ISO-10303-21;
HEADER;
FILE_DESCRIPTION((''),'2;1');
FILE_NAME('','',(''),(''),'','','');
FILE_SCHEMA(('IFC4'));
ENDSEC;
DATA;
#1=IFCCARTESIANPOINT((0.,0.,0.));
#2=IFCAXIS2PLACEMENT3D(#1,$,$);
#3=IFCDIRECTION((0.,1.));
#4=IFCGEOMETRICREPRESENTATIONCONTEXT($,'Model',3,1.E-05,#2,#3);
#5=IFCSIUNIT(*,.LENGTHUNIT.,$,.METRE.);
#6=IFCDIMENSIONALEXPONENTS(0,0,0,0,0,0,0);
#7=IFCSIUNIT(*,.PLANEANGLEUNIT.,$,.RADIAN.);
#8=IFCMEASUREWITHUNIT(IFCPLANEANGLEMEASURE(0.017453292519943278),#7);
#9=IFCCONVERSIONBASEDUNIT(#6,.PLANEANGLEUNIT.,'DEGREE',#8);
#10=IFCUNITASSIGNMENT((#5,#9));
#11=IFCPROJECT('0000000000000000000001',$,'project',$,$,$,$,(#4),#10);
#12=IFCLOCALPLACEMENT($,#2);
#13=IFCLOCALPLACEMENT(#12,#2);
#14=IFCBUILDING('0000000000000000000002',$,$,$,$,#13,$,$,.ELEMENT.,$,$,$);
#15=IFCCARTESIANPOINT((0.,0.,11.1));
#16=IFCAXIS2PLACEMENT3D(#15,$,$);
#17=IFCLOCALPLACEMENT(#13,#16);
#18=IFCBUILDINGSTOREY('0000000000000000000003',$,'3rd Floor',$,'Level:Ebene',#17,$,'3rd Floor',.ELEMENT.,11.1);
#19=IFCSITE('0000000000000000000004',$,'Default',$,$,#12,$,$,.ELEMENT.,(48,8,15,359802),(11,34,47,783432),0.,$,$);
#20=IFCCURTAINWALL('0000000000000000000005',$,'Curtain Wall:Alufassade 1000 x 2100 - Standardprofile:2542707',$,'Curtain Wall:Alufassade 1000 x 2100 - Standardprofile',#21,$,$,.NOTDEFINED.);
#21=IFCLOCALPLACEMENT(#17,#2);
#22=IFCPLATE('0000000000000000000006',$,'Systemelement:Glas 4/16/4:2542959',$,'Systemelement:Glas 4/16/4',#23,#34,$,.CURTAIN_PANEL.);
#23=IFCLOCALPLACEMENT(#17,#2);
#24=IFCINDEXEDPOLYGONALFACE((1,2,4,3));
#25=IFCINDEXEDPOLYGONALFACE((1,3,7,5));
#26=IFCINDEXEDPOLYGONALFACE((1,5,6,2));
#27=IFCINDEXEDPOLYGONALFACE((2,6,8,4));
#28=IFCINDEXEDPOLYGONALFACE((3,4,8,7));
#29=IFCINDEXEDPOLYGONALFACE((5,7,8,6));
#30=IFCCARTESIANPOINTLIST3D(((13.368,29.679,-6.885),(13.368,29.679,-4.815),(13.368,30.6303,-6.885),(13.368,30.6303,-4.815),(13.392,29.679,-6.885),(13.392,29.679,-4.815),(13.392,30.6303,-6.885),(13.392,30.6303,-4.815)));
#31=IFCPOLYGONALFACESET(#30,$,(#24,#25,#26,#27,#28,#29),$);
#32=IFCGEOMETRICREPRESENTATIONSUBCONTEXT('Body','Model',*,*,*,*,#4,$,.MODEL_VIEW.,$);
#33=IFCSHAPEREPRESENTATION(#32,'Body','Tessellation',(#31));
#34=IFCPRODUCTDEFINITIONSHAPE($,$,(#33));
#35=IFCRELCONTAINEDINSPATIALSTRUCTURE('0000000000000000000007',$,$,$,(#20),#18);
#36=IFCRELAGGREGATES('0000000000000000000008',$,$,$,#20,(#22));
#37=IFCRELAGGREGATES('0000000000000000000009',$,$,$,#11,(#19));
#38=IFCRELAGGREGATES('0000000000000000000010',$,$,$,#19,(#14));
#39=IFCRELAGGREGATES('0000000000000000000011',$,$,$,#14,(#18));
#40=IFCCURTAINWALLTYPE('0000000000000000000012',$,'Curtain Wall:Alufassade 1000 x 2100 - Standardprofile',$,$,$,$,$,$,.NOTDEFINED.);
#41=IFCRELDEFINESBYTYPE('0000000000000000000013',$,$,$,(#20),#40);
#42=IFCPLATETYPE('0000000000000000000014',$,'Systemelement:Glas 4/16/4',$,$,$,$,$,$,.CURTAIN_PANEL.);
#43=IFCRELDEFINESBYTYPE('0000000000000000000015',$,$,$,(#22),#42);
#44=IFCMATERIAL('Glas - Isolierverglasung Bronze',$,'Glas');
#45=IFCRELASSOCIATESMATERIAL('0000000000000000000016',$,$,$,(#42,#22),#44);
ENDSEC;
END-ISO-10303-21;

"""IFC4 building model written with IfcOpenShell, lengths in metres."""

from ifc_helpers import new_model, entity, si_unit, converted_unit, direction, frame, origin, place, context, subcontext, project, spatial, indexed_curve, outline, extrude, source, transform, mapped, material, type_object, type_shapes, element, aggregate, save


model = new_model("IFC4")

# Units and contexts
model_context = context("Model", 3, precision=1e-05, world=origin(), true_north=direction((0.0, 1.0)))
body_context = subcontext(model_context, "Body", "Model", "MODEL_VIEW")
ifc_project = project(units=[si_unit("LENGTHUNIT", "METRE"), converted_unit("PLANEANGLEUNIT", "DEGREE", entity("IfcPlaneAngleMeasure", 0.017453292519943278), si_unit("PLANEANGLEUNIT", "RADIAN"), dimensions=[0, 0, 0, 0, 0, 0, 0])], contexts=[model_context])

# Site, building, storey
site_placement = place(None, origin())
site = spatial("IfcSite", under=ifc_project, at=site_placement, Name="Default", CompositionType="ELEMENT", RefLatitude=(48, 8, 15, 359802), RefLongitude=(11, 34, 47, 783432), RefElevation=0.0)
building_placement = place(site_placement, origin())
building = spatial("IfcBuilding", under=site, at=building_placement, CompositionType="ELEMENT")
storey_placement = place(building_placement, frame((0.0, 0.0, 11.1)))
storey = spatial("IfcBuildingStorey", under=building, at=storey_placement, Name="3rd Floor", ObjectType="Level:Ebene", LongName="3rd Floor", CompositionType="ELEMENT", Elevation=11.1)

# Curtain wall
curtain_wall_type = type_object("IfcCurtainWallType", Name="Curtain Wall:Alufassade 1000 x 2100 - Standardprofile", PredefinedType="NOTDEFINED")
curtain_wall_1_placement = place(storey_placement, frame((0.0, 0.0, -11.1)))
curtain_wall_1 = element("IfcCurtainWall", 1, at=curtain_wall_1_placement, inside=storey, type_object=curtain_wall_type, Name="Curtain Wall:Alufassade 1000 x 2100 - Standardprofile:2542707", ObjectType="Curtain Wall:Alufassade 1000 x 2100 - Standardprofile", PredefinedType="NOTDEFINED")

# Plate
ifc_material_1 = material(Name="Glas - Isolierverglasung Bronze", Category="Glas")
plate_type_1 = type_object("IfcPlateType", Name="Systemelement:Glas 4/16/4", PredefinedType="CURTAIN_PANEL", material=ifc_material_1)
shared_shape_1 = source(origin(), body_context, "Body", "SweptSolid", [
    extrude(outline(indexed_curve([(-0.012, -0.4756), (0.012, -0.4756), (0.012, 0.4756), (-0.012, 0.4756), (-0.012, -0.4756)], self_intersect=False)), frame((0.0, 0.0, 0.0), z_axis=(0.0, 0.0, 1.0), x_axis=(0.0, 1.0, 0.0)), (0.0, 0.0, 1.0), 2.07),
])
type_shapes(plate_type_1, [shared_shape_1])
plate_1_placement = place(curtain_wall_1_placement, frame((13.38, 30.1546, 4.215), z_axis=(0.0, 0.0, 1.0), x_axis=(0.0, -1.0, 0.0)))
plate_1 = element("IfcPlate", 2, at=plate_1_placement, type_object=plate_type_1, material=ifc_material_1, Name="Systemelement:Glas 4/16/4:2542959", ObjectType="Systemelement:Glas 4/16/4", PredefinedType="CURTAIN_PANEL", context=body_context, shape_type="MappedRepresentation", body=[
    mapped(shared_shape_1, transform((0.0, 0.0, 0.0), scale=1.0)),
])
aggregate(curtain_wall_1, [plate_1])

save(model, "model.ifc")
